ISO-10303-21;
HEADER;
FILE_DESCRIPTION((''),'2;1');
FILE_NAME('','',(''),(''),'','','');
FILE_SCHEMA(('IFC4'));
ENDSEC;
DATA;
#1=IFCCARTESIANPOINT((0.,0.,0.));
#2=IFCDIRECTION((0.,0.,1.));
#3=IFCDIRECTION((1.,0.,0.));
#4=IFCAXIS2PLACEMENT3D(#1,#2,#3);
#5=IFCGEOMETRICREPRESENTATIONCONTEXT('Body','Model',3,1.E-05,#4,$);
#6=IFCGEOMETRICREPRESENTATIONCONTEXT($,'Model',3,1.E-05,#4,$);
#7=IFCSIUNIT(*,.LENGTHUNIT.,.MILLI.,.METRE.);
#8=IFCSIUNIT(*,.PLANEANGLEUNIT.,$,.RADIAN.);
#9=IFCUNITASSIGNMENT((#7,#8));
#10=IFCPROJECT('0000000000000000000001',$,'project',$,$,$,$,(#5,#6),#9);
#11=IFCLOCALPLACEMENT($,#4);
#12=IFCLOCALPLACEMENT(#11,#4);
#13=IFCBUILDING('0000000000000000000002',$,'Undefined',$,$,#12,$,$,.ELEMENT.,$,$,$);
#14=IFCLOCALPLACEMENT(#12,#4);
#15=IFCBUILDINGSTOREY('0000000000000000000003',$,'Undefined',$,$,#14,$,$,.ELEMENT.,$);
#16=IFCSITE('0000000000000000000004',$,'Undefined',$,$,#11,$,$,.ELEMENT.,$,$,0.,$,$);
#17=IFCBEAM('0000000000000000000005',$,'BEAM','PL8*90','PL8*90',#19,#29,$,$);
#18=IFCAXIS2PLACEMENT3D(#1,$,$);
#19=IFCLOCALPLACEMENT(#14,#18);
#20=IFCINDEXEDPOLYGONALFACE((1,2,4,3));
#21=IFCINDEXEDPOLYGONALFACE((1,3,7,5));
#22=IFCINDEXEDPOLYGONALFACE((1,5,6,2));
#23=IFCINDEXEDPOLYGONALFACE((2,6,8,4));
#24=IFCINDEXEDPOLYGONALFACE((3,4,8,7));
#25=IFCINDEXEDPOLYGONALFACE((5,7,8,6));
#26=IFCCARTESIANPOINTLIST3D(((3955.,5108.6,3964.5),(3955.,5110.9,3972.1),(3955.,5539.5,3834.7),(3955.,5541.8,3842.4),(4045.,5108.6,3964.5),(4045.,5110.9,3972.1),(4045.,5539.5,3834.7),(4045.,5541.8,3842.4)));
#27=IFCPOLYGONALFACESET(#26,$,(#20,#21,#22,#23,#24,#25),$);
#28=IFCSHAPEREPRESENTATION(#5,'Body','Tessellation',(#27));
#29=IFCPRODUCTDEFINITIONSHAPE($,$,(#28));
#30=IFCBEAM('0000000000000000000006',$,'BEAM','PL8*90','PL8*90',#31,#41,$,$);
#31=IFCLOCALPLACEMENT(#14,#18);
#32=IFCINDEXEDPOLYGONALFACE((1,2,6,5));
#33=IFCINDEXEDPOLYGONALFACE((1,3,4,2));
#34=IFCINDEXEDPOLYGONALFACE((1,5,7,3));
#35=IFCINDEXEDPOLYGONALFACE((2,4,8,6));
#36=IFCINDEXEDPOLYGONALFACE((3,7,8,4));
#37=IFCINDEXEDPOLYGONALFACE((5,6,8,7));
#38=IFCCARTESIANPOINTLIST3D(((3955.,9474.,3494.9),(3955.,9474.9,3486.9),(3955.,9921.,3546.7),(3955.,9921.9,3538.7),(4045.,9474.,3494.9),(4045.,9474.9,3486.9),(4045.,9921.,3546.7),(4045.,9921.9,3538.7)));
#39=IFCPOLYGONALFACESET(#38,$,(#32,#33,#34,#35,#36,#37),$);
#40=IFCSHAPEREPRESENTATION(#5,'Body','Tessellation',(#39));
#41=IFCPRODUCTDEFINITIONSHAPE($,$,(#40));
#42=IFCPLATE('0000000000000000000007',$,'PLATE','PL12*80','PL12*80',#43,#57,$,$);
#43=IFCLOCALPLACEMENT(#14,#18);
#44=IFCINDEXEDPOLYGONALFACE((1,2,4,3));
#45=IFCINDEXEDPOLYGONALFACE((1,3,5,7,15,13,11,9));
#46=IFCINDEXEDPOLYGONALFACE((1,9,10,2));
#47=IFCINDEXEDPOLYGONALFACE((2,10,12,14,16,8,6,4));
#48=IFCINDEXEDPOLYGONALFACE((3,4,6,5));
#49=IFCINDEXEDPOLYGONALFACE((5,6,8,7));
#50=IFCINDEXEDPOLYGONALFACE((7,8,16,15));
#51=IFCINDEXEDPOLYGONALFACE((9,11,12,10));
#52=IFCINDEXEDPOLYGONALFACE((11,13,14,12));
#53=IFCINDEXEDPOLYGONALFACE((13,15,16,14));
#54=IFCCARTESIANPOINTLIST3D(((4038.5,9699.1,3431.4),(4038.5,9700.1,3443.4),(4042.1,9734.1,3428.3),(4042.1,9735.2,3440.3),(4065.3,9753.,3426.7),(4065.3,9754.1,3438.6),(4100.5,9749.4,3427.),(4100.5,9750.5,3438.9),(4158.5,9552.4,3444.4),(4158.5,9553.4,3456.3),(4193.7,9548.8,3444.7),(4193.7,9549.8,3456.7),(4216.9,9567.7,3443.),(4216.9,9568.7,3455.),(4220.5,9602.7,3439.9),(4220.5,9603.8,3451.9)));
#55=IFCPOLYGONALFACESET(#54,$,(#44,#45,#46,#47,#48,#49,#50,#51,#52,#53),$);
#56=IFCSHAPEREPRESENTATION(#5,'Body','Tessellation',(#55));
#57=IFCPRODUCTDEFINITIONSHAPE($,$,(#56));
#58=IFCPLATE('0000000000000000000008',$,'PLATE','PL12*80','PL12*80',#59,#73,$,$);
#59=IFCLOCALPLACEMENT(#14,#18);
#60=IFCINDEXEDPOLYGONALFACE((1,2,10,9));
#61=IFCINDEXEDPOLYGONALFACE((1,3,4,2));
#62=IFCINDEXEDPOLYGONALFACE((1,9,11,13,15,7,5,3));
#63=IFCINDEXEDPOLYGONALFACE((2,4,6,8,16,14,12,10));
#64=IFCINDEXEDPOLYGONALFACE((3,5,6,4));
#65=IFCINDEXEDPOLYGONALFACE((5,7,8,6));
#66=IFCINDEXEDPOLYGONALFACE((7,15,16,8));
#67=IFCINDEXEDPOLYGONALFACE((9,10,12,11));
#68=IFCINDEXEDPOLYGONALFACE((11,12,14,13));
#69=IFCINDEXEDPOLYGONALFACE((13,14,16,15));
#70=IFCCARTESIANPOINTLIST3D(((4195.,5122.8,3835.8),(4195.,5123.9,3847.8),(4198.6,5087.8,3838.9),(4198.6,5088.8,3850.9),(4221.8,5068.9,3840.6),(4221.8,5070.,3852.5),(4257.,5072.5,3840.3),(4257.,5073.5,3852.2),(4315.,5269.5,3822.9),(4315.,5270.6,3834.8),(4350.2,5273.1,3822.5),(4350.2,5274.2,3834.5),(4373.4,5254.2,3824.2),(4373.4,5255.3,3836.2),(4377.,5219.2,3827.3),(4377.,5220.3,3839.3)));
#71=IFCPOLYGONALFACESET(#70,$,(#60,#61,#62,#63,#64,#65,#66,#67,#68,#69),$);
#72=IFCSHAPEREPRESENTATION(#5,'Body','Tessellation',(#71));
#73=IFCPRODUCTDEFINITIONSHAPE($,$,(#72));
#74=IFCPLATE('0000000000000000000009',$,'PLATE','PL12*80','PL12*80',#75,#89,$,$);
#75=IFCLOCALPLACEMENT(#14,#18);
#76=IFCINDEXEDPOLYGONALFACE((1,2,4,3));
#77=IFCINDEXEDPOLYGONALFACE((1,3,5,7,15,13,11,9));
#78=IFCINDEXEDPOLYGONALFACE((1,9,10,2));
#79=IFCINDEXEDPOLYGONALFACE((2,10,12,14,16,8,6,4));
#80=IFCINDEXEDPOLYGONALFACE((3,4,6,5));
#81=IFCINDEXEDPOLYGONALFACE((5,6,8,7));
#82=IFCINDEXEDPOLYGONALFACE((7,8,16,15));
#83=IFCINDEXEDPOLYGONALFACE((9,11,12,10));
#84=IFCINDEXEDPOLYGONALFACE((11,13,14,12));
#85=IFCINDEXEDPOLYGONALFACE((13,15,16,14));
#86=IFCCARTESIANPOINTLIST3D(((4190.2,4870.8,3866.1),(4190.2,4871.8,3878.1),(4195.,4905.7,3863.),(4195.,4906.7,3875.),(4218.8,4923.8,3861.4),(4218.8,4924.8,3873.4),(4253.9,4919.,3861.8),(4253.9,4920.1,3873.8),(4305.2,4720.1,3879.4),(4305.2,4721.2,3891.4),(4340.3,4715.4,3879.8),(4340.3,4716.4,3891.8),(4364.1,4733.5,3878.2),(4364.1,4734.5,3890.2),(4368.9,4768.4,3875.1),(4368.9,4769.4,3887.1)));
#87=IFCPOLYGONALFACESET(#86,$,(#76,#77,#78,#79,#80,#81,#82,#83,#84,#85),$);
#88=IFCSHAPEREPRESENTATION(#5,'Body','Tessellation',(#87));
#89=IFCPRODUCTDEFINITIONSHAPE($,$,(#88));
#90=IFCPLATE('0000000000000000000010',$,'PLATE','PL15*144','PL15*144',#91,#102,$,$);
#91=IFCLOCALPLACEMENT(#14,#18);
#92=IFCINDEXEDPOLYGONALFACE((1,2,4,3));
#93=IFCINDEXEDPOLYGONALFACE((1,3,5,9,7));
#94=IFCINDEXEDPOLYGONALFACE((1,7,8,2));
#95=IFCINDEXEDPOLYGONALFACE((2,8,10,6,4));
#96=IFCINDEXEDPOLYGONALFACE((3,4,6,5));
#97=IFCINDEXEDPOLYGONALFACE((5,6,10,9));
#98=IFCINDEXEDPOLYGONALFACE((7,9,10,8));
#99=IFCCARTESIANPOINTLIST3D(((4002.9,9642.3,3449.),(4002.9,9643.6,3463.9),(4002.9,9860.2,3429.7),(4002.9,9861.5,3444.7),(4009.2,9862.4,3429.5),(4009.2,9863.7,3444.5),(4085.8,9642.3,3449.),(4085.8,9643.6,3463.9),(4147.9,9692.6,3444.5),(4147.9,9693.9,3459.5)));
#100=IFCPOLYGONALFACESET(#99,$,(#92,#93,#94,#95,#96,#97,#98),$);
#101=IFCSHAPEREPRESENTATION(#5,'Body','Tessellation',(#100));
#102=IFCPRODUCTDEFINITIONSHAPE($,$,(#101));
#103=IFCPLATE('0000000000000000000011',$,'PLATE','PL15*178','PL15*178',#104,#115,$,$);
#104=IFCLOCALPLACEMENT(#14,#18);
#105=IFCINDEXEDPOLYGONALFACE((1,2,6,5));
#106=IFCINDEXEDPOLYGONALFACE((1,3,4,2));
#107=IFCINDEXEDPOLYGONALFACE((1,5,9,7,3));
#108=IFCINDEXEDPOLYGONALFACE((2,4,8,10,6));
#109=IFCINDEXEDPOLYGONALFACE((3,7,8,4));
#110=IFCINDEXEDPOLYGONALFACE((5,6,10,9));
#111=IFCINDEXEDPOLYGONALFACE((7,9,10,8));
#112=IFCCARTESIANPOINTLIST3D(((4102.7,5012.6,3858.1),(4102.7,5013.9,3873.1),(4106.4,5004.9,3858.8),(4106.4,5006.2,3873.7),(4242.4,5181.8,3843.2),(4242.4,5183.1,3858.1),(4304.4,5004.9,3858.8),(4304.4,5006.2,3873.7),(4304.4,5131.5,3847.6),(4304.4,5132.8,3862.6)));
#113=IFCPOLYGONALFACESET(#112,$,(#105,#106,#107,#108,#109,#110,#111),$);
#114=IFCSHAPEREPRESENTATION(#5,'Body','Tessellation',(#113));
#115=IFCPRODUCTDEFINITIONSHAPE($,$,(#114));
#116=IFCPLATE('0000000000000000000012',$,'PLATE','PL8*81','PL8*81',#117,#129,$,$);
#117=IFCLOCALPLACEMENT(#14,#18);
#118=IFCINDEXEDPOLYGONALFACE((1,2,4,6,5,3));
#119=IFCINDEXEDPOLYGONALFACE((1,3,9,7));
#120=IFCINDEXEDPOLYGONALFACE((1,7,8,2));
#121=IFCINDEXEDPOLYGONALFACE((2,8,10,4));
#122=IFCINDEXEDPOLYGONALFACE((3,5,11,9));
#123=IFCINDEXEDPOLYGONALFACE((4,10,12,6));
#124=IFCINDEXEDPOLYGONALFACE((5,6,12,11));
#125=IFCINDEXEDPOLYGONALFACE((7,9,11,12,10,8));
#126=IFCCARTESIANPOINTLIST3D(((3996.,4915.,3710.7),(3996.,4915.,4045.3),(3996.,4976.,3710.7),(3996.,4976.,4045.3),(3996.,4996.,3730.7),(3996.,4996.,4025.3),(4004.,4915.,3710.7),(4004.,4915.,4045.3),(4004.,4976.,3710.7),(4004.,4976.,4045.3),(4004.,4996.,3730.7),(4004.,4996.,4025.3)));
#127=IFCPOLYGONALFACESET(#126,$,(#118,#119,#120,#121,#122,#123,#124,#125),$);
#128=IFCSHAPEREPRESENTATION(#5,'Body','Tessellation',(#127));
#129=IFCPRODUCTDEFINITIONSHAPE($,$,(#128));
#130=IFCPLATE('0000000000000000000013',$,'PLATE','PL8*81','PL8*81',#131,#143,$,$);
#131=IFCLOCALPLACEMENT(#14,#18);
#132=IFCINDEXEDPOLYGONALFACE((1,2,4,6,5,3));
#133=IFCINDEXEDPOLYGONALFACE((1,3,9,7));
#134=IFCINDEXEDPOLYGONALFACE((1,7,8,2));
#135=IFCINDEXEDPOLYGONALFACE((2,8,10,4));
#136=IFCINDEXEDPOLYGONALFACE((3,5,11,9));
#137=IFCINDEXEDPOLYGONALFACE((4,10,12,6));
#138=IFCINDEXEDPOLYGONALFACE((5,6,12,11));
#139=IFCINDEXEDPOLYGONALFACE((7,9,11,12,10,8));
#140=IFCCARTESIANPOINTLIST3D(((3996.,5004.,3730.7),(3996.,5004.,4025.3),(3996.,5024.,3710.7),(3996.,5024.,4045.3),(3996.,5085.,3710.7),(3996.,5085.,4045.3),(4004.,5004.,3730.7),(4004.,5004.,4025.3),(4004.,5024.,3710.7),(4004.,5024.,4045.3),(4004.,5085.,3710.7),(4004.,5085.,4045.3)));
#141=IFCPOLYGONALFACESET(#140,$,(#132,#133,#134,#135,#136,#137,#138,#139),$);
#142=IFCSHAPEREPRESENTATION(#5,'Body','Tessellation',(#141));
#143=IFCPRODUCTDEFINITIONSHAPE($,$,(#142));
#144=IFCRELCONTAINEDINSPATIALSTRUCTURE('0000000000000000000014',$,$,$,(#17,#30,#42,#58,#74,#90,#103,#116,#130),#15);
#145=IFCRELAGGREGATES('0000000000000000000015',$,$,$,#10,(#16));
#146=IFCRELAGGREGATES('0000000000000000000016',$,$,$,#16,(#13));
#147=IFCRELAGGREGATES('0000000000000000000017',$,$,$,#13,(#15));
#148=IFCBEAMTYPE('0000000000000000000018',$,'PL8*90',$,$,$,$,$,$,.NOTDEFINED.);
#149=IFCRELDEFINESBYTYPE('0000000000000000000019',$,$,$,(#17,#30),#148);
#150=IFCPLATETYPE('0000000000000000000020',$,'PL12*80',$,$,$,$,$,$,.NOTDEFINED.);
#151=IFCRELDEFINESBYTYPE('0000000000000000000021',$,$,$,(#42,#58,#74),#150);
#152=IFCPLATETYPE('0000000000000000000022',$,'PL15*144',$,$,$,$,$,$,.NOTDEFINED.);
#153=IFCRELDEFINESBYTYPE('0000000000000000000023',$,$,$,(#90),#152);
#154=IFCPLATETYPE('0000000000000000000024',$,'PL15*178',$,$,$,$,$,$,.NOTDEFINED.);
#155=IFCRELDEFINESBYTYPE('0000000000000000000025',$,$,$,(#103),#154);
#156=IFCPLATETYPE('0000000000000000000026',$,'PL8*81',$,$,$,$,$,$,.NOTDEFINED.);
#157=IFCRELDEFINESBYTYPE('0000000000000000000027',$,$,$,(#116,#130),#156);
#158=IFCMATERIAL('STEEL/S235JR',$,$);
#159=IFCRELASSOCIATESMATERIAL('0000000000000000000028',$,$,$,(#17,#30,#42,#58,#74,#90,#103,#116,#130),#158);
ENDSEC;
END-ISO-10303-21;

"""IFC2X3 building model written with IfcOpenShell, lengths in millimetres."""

from ifc_helpers import new_model, si_unit, frame, origin_with_axes, origin_2d_with_axis, place, context, project, spatial, polyline, rectangle, outline, extrude, material, type_object, element, save


model = new_model("IFC2X3")

# Units and contexts
model_context_1 = context("Model", 3, precision=1e-05, world=origin_with_axes(), identifier="Body")
model_context_2 = context("Model", 3, precision=1e-05, world=origin_with_axes())
ifc_project = project(units=[si_unit("LENGTHUNIT", "METRE", prefix="MILLI"), si_unit("PLANEANGLEUNIT", "RADIAN")], contexts=[model_context_1, model_context_2])

# Site, building, storey
site_placement = place(None, origin_with_axes())
site = spatial("IfcSite", under=ifc_project, at=site_placement, Name="Undefined", CompositionType="ELEMENT", RefElevation=0.0)
building_placement = place(site_placement, origin_with_axes())
building = spatial("IfcBuilding", under=site, at=building_placement, Name="Undefined", CompositionType="ELEMENT")
storey_placement = place(building_placement, origin_with_axes())
storey = spatial("IfcBuildingStorey", under=building, at=storey_placement, Name="Undefined", CompositionType="ELEMENT")

# Shared definitions
ifc_material = material(Name="STEEL/S235JR")

# Beams
beam_type_1 = type_object("IfcBeamType", Name="PL8*90", PredefinedType="NOTDEFINED")
beam_1_placement = place(storey_placement, frame((4000.0, 5109.8, 3968.3), z_axis=(1.0, 0.0, 0.0), x_axis=(0.0, 0.957545, -0.288283)))
element("IfcBeam", 1, at=beam_1_placement, inside=storey, type_object=beam_type_1, material=ifc_material, Name="BEAM", Description="PL8*90", ObjectType="PL8*90", context=model_context_1, shape_type="SweptSolid", body=[
    extrude(rectangle(XDim=8.0, YDim=90.0, at=origin_2d_with_axis()), frame((450.0, 0.0, 0.0), z_axis=(-1.0, 0.0, 0.0), x_axis=(0.0, -1.0, 0.0)), (0.0, 0.0, 1.0), 450.0),
])
beam_2_placement = place(storey_placement, frame((4000.0, 9921.4, 3542.7), z_axis=(1.0, 0.0, 0.0), x_axis=(0.0, -0.993355, -0.115087)))
element("IfcBeam", 2, at=beam_2_placement, inside=storey, type_object=beam_type_1, material=ifc_material, Name="BEAM", Description="PL8*90", ObjectType="PL8*90", context=model_context_1, shape_type="SweptSolid", body=[
    extrude(rectangle(XDim=8.0, YDim=90.0, at=origin_2d_with_axis()), frame((450.0, 0.0, 0.0), z_axis=(-1.0, 0.0, 0.0), x_axis=(0.0, -1.0, 0.0)), (0.0, 0.0, 1.0), 450.0),
])

# Plates
plate_type_1 = type_object("IfcPlateType", Name="PL12*80", PredefinedType="NOTDEFINED")
for number, where, z_axis, x_axis, name in (
    (3, (4174.3, 9533.6, 3452.1), (-0.000001, 0.088031, 0.996118), (0.775235, 0.629221, -0.055604), "PLATE"),
    (4, (4241.2, 5053.7, 3848.0), (0.0, -0.088027, -0.996118), (-0.775235, 0.629221, -0.055606), "PLATE"),
    (5, (4175.1, 4891.1, 3870.3), (0.000003, -0.088001, -0.99612), (0.795939, 0.603028, -0.053273), "PLATE"),
):
    element("IfcPlate", number, at=place(storey_placement, frame(where, z_axis=z_axis, x_axis=x_axis)), inside=storey, type_object=plate_type_1, material=ifc_material, Name=name, Description="PL12*80", ObjectType="PL12*80", context=model_context_1, shape_type="SweptSolid", body=[
        extrude(outline(polyline([(0.0, 25.0), (25.0, 0.0), (55.0, 0.0), (80.0, 25.0), (80.0, 215.0), (55.0, 240.0), (25.0, 240.0), (0.0, 215.0), (0.0, 25.0)])), frame((0.0, 0.0, -6.0), z_axis=(0.0, 0.0, 1.0), x_axis=(1.0, 0.0, 0.0)), (0.0, 0.0, 1.0), 12.0),
    ])
plate_type_2 = type_object("IfcPlateType", Name="PL15*144", PredefinedType="NOTDEFINED")
plate_1_placement = place(storey_placement, frame((4002.9, 9642.9, 3456.5), z_axis=(0.00002, -0.08801, -0.99612), x_axis=(0.0, 0.99612, -0.08801)))
element("IfcPlate", 6, at=plate_1_placement, inside=storey, type_object=plate_type_2, material=ifc_material, Name="PLATE", Description="PL15*144", ObjectType="PL15*144", context=model_context_1, shape_type="SweptSolid", body=[
    extrude(outline(polyline([(0.0, 0.0), (218.8, 0.0), (221.0, 6.3), (50.5, 145.0), (0.0, 82.9), (0.0, 0.0)])), frame((0.0, 0.0, -7.5), z_axis=(0.0, 0.0, 1.0), x_axis=(1.0, 0.0, 0.0)), (0.0, 0.0, 1.0), 15.0),
])
plate_type_3 = type_object("IfcPlateType", Name="PL15*178", PredefinedType="NOTDEFINED")
plate_2_placement = place(storey_placement, frame((4304.4, 5005.6, 3866.3), z_axis=(0.0, -0.088027, -0.996118), x_axis=(-1.0, 0.0, 0.0)))
element("IfcPlate", 7, at=plate_2_placement, inside=storey, type_object=plate_type_3, material=ifc_material, Name="PLATE", Description="PL15*178", ObjectType="PL15*178", context=model_context_1, shape_type="SweptSolid", body=[
    extrude(outline(polyline([(0.0, 0.0), (198.0, 0.0), (201.7, 7.7), (62.0, 177.6), (0.0, 127.1), (0.0, 0.0)])), frame((0.0, 0.0, -7.5), z_axis=(0.0, 0.0, 1.0), x_axis=(1.0, 0.0, 0.0)), (0.0, 0.0, 1.0), 15.0),
])
plate_type_4 = type_object("IfcPlateType", Name="PL8*81", PredefinedType="NOTDEFINED")
for number, where, z_axis, x_axis, name in (
    (8, (4000.0, 4996.0, 3710.7), (-1.0, 0.0, 0.0), (0.0, -1.0, 0.0), "PLATE"),
    (9, (4000.0, 5004.0, 3710.7), (1.0, 0.0, 0.0), (0.0, 1.0, 0.0), "PLATE"),
):
    element("IfcPlate", number, at=place(storey_placement, frame(where, z_axis=z_axis, x_axis=x_axis)), inside=storey, type_object=plate_type_4, material=ifc_material, Name=name, Description="PL8*81", ObjectType="PL8*81", context=model_context_1, shape_type="SweptSolid", body=[
        extrude(outline(polyline([(0.0, 20.0), (20.0, 0.0), (81.0, 0.0), (81.0, 334.6), (20.0, 334.6), (0.0, 314.6), (0.0, 20.0)])), frame((0.0, 0.0, -4.0), z_axis=(0.0, 0.0, 1.0), x_axis=(1.0, 0.0, 0.0)), (0.0, 0.0, 1.0), 8.0),
    ])

save(model, "model.ifc")
